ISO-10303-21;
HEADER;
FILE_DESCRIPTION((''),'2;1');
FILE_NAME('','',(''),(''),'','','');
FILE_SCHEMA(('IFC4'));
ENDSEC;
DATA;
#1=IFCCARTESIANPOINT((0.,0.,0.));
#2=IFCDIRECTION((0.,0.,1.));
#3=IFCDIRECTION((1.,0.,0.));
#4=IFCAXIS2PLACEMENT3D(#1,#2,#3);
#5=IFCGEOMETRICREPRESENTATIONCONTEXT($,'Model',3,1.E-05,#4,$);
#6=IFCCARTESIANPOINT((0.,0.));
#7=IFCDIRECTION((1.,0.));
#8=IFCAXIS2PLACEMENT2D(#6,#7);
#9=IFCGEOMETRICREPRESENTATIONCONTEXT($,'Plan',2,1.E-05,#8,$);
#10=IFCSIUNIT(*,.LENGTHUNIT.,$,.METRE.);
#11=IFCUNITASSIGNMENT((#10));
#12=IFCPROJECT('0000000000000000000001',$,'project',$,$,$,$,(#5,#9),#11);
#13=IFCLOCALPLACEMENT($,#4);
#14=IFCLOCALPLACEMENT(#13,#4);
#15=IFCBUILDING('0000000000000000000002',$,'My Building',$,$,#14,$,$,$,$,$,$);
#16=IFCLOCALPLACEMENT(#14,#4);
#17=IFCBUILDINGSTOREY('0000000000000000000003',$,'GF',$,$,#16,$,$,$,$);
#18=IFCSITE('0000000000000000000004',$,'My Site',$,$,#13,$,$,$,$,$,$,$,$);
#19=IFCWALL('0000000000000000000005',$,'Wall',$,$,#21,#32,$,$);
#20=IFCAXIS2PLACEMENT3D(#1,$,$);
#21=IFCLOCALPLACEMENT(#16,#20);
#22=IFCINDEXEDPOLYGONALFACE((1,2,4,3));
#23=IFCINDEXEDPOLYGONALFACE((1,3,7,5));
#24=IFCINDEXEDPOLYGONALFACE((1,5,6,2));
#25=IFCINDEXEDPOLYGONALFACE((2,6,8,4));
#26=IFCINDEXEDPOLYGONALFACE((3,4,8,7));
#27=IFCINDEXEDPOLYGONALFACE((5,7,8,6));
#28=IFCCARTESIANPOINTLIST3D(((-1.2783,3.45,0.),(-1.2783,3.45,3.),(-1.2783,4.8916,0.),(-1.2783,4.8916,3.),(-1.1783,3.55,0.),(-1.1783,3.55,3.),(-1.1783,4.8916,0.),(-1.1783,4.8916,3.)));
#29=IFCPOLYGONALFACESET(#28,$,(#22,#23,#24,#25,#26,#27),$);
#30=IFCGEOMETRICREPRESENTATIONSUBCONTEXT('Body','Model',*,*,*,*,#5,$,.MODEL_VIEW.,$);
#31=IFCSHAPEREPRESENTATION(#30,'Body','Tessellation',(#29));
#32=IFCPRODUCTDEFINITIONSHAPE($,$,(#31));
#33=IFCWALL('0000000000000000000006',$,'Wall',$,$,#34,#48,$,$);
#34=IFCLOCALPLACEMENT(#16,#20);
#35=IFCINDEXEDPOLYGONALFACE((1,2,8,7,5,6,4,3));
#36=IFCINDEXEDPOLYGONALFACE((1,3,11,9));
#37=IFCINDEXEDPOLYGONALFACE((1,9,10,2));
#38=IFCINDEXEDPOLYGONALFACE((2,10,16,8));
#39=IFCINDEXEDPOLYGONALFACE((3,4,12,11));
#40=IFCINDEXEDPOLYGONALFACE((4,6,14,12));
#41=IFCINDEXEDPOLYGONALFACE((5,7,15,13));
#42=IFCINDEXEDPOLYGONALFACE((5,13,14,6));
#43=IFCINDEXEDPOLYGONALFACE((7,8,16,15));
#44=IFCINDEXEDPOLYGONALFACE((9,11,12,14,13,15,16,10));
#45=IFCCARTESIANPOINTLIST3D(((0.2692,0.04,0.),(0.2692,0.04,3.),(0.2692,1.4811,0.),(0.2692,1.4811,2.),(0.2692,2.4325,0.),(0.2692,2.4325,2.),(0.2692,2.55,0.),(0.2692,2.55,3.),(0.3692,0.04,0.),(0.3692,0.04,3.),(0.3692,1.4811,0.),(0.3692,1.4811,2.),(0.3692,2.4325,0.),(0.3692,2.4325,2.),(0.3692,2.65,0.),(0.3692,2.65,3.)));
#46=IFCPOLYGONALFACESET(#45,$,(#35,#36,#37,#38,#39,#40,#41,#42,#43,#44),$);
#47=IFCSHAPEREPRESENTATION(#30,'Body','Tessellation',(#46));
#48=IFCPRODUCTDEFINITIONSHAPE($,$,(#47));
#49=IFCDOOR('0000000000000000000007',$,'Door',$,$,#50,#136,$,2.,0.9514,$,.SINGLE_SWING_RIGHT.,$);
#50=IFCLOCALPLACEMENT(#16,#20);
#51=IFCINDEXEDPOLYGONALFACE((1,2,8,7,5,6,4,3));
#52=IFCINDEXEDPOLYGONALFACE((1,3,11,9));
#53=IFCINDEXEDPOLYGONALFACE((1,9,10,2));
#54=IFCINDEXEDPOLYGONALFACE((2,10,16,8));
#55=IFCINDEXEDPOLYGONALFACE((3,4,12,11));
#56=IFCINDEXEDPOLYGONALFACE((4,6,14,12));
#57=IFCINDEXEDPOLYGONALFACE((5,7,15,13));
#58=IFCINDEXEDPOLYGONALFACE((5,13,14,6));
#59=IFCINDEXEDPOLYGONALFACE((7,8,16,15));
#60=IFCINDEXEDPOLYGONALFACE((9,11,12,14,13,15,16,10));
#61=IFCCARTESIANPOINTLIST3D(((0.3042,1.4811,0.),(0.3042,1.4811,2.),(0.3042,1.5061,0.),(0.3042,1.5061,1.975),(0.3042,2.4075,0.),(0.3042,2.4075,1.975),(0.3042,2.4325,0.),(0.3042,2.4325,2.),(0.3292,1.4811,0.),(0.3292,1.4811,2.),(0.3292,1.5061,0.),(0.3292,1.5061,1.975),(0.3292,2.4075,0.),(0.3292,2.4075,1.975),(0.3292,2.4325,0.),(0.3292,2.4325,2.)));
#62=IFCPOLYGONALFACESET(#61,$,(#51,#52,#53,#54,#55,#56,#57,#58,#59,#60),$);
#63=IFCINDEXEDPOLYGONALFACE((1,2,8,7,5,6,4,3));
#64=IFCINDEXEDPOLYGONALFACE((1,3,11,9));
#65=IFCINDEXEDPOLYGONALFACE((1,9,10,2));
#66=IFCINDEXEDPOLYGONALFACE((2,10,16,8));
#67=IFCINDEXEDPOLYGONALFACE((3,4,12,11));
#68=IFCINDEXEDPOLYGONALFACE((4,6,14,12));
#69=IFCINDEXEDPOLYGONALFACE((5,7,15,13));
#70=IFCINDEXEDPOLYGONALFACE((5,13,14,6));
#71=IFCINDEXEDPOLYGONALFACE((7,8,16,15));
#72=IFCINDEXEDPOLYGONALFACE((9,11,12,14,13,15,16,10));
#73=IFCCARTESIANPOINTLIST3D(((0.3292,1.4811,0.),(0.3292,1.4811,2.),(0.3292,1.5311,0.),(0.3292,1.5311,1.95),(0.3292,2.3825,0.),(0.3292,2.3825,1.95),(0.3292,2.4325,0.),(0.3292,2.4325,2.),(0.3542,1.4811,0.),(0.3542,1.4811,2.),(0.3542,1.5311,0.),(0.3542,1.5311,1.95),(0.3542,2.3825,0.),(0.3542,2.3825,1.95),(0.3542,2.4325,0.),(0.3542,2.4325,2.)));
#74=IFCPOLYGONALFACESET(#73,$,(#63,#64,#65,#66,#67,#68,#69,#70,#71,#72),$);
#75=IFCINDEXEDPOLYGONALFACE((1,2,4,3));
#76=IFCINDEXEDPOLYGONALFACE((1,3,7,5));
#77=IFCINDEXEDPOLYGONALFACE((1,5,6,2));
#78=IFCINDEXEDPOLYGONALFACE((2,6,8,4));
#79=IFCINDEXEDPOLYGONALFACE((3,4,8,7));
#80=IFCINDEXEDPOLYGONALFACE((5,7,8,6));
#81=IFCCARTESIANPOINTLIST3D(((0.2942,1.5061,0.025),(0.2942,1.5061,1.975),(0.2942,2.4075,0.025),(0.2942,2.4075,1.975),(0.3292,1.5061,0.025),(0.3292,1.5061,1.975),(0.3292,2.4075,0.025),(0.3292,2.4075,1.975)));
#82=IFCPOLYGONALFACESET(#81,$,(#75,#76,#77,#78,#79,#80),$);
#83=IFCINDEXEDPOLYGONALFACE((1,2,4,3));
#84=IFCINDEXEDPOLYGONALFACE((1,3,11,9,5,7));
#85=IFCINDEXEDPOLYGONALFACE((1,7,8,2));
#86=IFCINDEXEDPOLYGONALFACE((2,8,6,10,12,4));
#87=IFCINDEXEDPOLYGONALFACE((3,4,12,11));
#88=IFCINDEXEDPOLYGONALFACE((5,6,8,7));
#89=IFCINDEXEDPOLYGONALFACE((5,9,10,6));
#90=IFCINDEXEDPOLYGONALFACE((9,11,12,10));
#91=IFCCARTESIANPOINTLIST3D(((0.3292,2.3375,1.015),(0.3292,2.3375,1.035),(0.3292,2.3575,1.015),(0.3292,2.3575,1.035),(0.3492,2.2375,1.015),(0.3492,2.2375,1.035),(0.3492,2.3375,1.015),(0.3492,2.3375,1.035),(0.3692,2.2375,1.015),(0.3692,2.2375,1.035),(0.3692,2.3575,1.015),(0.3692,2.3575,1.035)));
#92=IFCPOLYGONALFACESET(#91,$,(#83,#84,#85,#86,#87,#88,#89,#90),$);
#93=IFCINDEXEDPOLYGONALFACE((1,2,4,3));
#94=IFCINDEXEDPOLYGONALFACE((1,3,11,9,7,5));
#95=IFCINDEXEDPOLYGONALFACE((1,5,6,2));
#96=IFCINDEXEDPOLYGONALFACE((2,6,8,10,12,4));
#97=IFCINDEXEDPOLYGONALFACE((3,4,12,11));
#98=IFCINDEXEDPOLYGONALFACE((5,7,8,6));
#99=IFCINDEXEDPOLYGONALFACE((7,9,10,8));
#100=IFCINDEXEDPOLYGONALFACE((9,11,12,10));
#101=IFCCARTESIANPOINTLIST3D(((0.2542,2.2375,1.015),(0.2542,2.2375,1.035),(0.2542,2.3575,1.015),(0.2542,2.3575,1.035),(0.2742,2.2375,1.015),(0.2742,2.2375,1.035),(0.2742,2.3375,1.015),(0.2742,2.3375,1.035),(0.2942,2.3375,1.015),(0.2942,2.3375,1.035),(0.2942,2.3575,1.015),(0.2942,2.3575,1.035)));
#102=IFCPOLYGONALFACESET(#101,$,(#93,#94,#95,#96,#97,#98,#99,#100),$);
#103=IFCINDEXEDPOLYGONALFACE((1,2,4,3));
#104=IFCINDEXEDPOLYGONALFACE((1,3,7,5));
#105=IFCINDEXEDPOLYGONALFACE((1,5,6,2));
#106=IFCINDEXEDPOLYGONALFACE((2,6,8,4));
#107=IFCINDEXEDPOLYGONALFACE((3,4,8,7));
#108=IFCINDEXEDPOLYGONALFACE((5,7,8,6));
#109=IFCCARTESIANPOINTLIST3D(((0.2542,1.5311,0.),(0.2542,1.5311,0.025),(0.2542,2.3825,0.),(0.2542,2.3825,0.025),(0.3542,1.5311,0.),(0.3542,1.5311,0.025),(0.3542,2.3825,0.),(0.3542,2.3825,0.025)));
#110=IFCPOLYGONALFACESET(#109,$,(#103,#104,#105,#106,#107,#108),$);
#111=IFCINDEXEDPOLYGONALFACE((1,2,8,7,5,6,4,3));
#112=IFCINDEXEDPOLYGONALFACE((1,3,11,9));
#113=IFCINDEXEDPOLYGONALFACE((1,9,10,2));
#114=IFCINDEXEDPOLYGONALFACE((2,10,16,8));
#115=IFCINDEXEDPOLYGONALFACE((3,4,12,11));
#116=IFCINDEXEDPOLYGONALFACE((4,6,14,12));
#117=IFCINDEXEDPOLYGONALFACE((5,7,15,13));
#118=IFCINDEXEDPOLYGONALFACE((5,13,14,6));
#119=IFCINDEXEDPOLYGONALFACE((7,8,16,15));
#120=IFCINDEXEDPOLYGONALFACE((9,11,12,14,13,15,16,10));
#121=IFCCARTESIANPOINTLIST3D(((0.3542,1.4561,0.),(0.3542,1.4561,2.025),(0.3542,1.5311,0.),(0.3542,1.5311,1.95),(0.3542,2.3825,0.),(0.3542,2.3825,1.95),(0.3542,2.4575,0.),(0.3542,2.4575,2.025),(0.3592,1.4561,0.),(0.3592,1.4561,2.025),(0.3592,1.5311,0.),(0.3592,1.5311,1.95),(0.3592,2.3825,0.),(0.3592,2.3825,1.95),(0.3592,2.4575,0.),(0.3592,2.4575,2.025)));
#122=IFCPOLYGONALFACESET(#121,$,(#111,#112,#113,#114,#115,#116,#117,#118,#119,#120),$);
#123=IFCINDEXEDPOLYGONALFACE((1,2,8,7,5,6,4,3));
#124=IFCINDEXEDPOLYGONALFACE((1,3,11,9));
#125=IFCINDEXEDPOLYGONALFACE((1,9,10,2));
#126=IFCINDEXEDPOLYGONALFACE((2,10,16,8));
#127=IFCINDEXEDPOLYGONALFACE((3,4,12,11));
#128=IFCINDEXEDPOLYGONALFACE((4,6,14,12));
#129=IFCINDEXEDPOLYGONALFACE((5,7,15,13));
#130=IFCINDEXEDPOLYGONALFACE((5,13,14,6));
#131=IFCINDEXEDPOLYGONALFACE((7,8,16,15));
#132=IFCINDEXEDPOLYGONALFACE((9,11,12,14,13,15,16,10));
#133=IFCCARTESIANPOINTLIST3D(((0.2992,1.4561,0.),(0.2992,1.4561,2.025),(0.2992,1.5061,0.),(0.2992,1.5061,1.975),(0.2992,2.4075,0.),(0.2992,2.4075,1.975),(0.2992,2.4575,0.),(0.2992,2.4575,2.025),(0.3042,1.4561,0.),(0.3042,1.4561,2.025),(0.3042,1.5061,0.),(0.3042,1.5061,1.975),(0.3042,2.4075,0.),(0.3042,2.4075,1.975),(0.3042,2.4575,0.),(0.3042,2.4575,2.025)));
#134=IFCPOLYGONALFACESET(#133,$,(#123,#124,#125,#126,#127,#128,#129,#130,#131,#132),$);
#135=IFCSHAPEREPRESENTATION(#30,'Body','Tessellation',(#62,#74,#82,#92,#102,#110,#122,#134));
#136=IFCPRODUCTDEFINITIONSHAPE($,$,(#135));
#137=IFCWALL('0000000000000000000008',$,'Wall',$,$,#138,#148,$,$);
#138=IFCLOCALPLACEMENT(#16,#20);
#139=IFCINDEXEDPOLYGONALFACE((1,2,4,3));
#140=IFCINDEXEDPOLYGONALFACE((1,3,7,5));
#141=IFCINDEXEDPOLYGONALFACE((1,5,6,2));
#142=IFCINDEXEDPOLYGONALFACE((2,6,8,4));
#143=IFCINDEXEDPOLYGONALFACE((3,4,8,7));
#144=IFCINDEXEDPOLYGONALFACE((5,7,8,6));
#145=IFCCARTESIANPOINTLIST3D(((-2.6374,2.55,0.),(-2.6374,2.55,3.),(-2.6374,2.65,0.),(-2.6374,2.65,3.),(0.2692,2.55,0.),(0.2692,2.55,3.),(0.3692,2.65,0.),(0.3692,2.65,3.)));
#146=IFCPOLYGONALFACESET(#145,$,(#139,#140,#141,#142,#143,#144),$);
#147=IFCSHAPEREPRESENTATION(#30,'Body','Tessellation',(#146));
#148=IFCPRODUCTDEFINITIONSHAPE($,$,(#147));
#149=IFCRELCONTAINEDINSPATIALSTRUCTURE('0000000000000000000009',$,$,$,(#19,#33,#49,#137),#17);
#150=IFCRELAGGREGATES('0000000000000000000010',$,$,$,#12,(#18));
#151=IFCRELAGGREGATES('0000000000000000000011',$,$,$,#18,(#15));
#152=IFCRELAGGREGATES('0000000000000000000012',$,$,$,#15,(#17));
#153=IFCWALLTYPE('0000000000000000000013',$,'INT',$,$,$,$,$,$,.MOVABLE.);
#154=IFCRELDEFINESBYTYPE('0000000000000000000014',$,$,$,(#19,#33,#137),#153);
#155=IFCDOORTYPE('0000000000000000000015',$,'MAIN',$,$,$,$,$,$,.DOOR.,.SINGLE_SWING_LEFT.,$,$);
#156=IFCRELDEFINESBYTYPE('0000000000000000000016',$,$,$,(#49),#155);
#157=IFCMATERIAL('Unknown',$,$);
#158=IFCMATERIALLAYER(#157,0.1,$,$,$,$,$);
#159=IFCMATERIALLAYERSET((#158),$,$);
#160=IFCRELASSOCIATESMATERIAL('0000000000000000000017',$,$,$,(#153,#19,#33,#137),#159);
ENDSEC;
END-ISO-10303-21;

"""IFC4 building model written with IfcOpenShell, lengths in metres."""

from ifc_helpers import new_model, entity, si_unit, frame, origin_with_axes, origin_2d_with_axis, place, context, subcontext, project, spatial, line, indexed_curve, outline, extrude, shape, source, transform, mapped, material, layer, layer_set, layer_usage, type_object, type_shapes, element, fill, save


model = new_model("IFC4")

# Units and contexts
model_context = context("Model", 3, precision=1e-05, world=origin_with_axes())
plan_context = context("Plan", 2, precision=1e-05, world=origin_2d_with_axis())
body_context_1 = subcontext(model_context, "Body", "Model", "MODEL_VIEW")
body_context_2 = subcontext(plan_context, "Body", "Plan", "PLAN_VIEW")
ifc_project = project(units=[si_unit("LENGTHUNIT", "METRE")], contexts=[model_context, plan_context])

# Site, building, storey
site_placement = place(None, origin_with_axes())
site = spatial("IfcSite", under=ifc_project, at=site_placement, Name="My Site")
building_placement = place(site_placement, origin_with_axes())
building = spatial("IfcBuilding", under=site, at=building_placement, Name="My Building")
storey_placement = place(building_placement, origin_with_axes())
storey = spatial("IfcBuildingStorey", under=building, at=storey_placement, Name="GF")

# Shared definitions
ifc_material = material(Name="Unknown")

# Shared definitions
door_type_1 = type_object("IfcDoorType", Name="MAIN", OperationType="SINGLE_SWING_LEFT", PredefinedType="DOOR")
shared_shape_1 = source(origin_with_axes(), body_context_1, "Body", "SweptSolid", [
    extrude(outline(indexed_curve([(0.0, 0.0), (0.0, 2.0), (0.9514, 2.0), (0.9514, 0.0), (0.9264, 0.0), (0.9264, 1.975), (0.025, 1.975), (0.025, 0.0)], segments=[line(1, 2, 3, 4, 5, 6, 7, 8, 1)])), frame((0.0, 0.025, 0.0), z_axis=(0.0, -1.0, 0.0), x_axis=(1.0, 0.0, 0.0)), (0.0, 0.0, -1.0), 0.025),
    extrude(outline(indexed_curve([(0.0, 0.0), (0.0, 2.0), (0.9514, 2.0), (0.9514, 0.0), (0.9014, 0.0), (0.9014, 1.95), (0.05, 1.95), (0.05, 0.0)], segments=[line(1, 2, 3, 4, 5, 6, 7, 8, 1)])), frame((0.0, 0.0, 0.0), z_axis=(0.0, -1.0, 0.0), x_axis=(1.0, 0.0, 0.0)), (0.0, 0.0, -1.0), 0.025),
    extrude(outline(indexed_curve([(0.0, 0.0), (0.9014, 0.0), (0.9014, 0.035), (0.0, 0.035)], segments=[line(1, 2, 3, 4, 1)])), frame((0.025, 0.025, 0.025), z_axis=(0.0, 0.0, 1.0), x_axis=(1.0, 0.0, 0.0)), (0.0, 0.0, 1.0), 1.95),
    extrude(outline(indexed_curve([(0.0, 0.0), (0.0, -0.04), (-0.12, -0.04), (-0.12, -0.02), (-0.02, -0.02), (-0.02, 0.0)], segments=[line(1, 2, 3, 4, 5, 6, 1)])), frame((0.8764, 0.025, 1.015), z_axis=(0.0, 0.0, 1.0), x_axis=(1.0, 0.0, 0.0)), (0.0, 0.0, 1.0), 0.02),
    extrude(outline(indexed_curve([(0.0, 0.0), (0.0, 0.04), (-0.12, 0.04), (-0.12, 0.02), (-0.02, 0.02), (-0.02, 0.0)], segments=[line(1, 2, 3, 4, 5, 6, 1)])), frame((0.8764, 0.06, 1.015), z_axis=(0.0, 0.0, 1.0), x_axis=(1.0, 0.0, 0.0)), (0.0, 0.0, 1.0), 0.02),
    extrude(outline(indexed_curve([(0.0, 0.0), (0.8514, 0.0), (0.8514, 0.1), (0.0, 0.1)], segments=[line(1, 2, 3, 4, 1)])), frame((0.05, 0.0, 0.0), z_axis=(0.0, 0.0, 1.0), x_axis=(1.0, 0.0, 0.0)), (0.0, 0.0, 1.0), 0.025),
    extrude(outline(indexed_curve([(0.0, 0.0), (0.0, 2.025), (1.0014, 2.025), (1.0014, 0.0), (0.9264, 0.0), (0.9264, 1.95), (0.075, 1.95), (0.075, 0.0)], segments=[line(1, 2, 3, 4, 5, 6, 7, 8, 1)])), frame((-0.025, -0.005, 0.0), z_axis=(0.0, -1.0, 0.0), x_axis=(1.0, 0.0, 0.0)), (0.0, 0.0, -1.0), 0.005),
    extrude(outline(indexed_curve([(0.0, 0.0), (0.0, 2.025), (1.0014, 2.025), (1.0014, 0.0), (0.9514, 0.0), (0.9514, 1.975), (0.05, 1.975), (0.05, 0.0)], segments=[line(1, 2, 3, 4, 5, 6, 7, 8, 1)])), frame((-0.025, 0.05, 0.0), z_axis=(0.0, -1.0, 0.0), x_axis=(1.0, 0.0, 0.0)), (0.0, 0.0, -1.0), 0.005),
])
shared_shape_2 = source(origin_with_axes(), body_context_2, "Body", "Curve2D", [
    entity("IfcIndexedPolyCurve", entity("IfcCartesianPointList2D", [[0.0, 0.0], [0.0, 0.05], [0.025, 0.05], [0.025, 0.025], [0.05, 0.025], [0.05, 0.0]]), [entity("IfcLineIndex", [1, 2, 3, 4, 5, 6, 1])]),
    entity("IfcIndexedPolyCurve", entity("IfcCartesianPointList2D", [[0.9514, 0.0], [0.9514, 0.05], [0.9264, 0.05], [0.9264, 0.025], [0.9014, 0.025], [0.9014, 0.0]]), [entity("IfcLineIndex", [1, 2, 3, 4, 5, 6, 1])]),
    entity("IfcTrimmedCurve", entity("IfcEllipse", entity("IfcAxis2Placement2D", entity("IfcCartesianPoint", [0.06, 0.05]), entity("IfcDirection", [1.0, 0.0])), 0.8664, 0.9014), [entity("IfcCartesianPoint", [0.9264, 0.05])], [entity("IfcCartesianPoint", [0.06, 0.9514])], True, "CARTESIAN"),
    entity("IfcIndexedPolyCurve", entity("IfcCartesianPointList2D", [[0.025, 0.05], [0.06, 0.05], [0.06, 0.9514], [0.025, 0.9514]]), [entity("IfcLineIndex", [1, 2, 3, 4, 1])]),
])
type_shapes(door_type_1, [shared_shape_1, shared_shape_2])

# Wall
ifc_layer_1 = layer(ifc_material, 0.1)
ifc_layer_set_1 = layer_set([ifc_layer_1])
wall_type_1 = type_object("IfcWallType", Name="INT", PredefinedType="MOVABLE", material=ifc_layer_set_1)
ifc_layer_usage_1 = layer_usage(ifc_layer_set_1, "AXIS2", "POSITIVE", -0.1)
wall_1_placement = place(storey_placement, frame((-1.2783, 3.45, 0.0), z_axis=(0.0, 0.0, 1.0), x_axis=(0.0, 1.0, 0.0)))
element("IfcWall", 1, at=wall_1_placement, inside=storey, type_object=wall_type_1, material=ifc_layer_usage_1, Name="Wall", context=body_context_1, shape_type="SweptSolid", body=[
    extrude(outline(indexed_curve([(0.1, -0.1), (0.0, 0.0), (1.4416, 0.0), (1.4416, -0.1)], segments=[line(1, 2, 3, 4, 1)])), origin_with_axes(), (0.0, 0.0, 1.0), 3.0),
])

# Wall, opening, door
ifc_layer_usage_2 = layer_usage(ifc_layer_set_1, "AXIS2", "POSITIVE", 0.0)
wall_2_placement = place(storey_placement, frame((0.3692, 0.04, 0.0), z_axis=(0.0, 0.0, 1.0), x_axis=(0.0, 1.0, 0.0)))
wall_2 = element("IfcWall", 2, at=wall_2_placement, inside=storey, type_object=wall_type_1, material=ifc_layer_usage_2, Name="Wall", context=body_context_1, shape_type="SweptSolid", body=[
    extrude(outline(indexed_curve([(0.0, 0.0), (0.0, 0.1), (2.51, 0.1), (2.61, 0.0)], segments=[line(1, 2, 3, 4, 1)])), origin_with_axes(), (0.0, 0.0, 1.0), 3.0),
])
shared_shape_3 = source(origin_with_axes(), body_context_1, "Body", "SweptSolid", [
    extrude(outline(indexed_curve([(0.0, 0.0), (0.9514, 0.0), (0.9514, 2.0), (0.0, 2.0)], segments=[line(1, 2, 3, 4, 1)])), frame((0.0, -0.6, 0.0), z_axis=(0.0, -1.0, 0.0), x_axis=(1.0, 0.0, 0.0)), (0.0, 0.0, -1.0), 1.2),
])
opening_1_placement = place(wall_2_placement, frame((1.4411, 0.015, 0.0), z_axis=(0.0, 0.0, 1.0), x_axis=(1.0, 0.0, 0.0)))
opening_1 = element("IfcOpeningElement", 3, at=opening_1_placement, cuts=wall_2, PredefinedType="OPENING", context=body_context_1, shape_type="MappedRepresentation", body=[
    mapped(shared_shape_3, transform((0.0, 0.0, 0.0), x_axis=(1.0, 0.0, 0.0), y_axis=(0.0, 1.0, 0.0), z_axis=(0.0, 0.0, 1.0), scale=1.0)),
])
door_1_placement = place(opening_1_placement, frame((0.0, 0.0, 0.0), z_axis=(0.0, 0.0, 1.0), x_axis=(1.0, 0.0, 0.0)))
door_1 = element("IfcDoor", 4, at=door_1_placement, inside=storey, type_object=door_type_1, Name="Door", OperationType="SINGLE_SWING_RIGHT", OverallHeight=2.0, OverallWidth=0.9514, shapes=[
    shape(body_context_1, "Body", "MappedRepresentation", [mapped(shared_shape_1, transform((0.0, 0.0, 0.0), x_axis=(1.0, 0.0, 0.0), y_axis=(0.0, 1.0, 0.0), z_axis=(0.0, 0.0, 1.0), scale=1.0))]),
    shape(body_context_2, "Body", "MappedRepresentation", [mapped(shared_shape_2, transform((0.0, 0.0, 0.0), x_axis=(1.0, 0.0, 0.0), y_axis=(0.0, 1.0, 0.0), z_axis=(0.0, 0.0, 1.0), scale=1.0))]),
])
fill(opening_1, door_1)

# Wall
ifc_layer_usage_3 = layer_usage(ifc_layer_set_1, "AXIS2", "POSITIVE", 0.0)
wall_3_placement = place(storey_placement, frame((0.3692, 2.65, 0.0), z_axis=(0.0, 0.0, 1.0), x_axis=(-1.0, 0.0, 0.0)))
element("IfcWall", 5, at=wall_3_placement, inside=storey, type_object=wall_type_1, material=ifc_layer_usage_3, Name="Wall", context=body_context_1, shape_type="SweptSolid", body=[
    extrude(outline(indexed_curve([(0.0, 0.0), (0.1, 0.1), (3.0066, 0.1), (3.0066, 0.0)], segments=[line(1, 2, 3, 4, 1)])), origin_with_axes(), (0.0, 0.0, 1.0), 3.0),
])

save(model, "model.ifc")
